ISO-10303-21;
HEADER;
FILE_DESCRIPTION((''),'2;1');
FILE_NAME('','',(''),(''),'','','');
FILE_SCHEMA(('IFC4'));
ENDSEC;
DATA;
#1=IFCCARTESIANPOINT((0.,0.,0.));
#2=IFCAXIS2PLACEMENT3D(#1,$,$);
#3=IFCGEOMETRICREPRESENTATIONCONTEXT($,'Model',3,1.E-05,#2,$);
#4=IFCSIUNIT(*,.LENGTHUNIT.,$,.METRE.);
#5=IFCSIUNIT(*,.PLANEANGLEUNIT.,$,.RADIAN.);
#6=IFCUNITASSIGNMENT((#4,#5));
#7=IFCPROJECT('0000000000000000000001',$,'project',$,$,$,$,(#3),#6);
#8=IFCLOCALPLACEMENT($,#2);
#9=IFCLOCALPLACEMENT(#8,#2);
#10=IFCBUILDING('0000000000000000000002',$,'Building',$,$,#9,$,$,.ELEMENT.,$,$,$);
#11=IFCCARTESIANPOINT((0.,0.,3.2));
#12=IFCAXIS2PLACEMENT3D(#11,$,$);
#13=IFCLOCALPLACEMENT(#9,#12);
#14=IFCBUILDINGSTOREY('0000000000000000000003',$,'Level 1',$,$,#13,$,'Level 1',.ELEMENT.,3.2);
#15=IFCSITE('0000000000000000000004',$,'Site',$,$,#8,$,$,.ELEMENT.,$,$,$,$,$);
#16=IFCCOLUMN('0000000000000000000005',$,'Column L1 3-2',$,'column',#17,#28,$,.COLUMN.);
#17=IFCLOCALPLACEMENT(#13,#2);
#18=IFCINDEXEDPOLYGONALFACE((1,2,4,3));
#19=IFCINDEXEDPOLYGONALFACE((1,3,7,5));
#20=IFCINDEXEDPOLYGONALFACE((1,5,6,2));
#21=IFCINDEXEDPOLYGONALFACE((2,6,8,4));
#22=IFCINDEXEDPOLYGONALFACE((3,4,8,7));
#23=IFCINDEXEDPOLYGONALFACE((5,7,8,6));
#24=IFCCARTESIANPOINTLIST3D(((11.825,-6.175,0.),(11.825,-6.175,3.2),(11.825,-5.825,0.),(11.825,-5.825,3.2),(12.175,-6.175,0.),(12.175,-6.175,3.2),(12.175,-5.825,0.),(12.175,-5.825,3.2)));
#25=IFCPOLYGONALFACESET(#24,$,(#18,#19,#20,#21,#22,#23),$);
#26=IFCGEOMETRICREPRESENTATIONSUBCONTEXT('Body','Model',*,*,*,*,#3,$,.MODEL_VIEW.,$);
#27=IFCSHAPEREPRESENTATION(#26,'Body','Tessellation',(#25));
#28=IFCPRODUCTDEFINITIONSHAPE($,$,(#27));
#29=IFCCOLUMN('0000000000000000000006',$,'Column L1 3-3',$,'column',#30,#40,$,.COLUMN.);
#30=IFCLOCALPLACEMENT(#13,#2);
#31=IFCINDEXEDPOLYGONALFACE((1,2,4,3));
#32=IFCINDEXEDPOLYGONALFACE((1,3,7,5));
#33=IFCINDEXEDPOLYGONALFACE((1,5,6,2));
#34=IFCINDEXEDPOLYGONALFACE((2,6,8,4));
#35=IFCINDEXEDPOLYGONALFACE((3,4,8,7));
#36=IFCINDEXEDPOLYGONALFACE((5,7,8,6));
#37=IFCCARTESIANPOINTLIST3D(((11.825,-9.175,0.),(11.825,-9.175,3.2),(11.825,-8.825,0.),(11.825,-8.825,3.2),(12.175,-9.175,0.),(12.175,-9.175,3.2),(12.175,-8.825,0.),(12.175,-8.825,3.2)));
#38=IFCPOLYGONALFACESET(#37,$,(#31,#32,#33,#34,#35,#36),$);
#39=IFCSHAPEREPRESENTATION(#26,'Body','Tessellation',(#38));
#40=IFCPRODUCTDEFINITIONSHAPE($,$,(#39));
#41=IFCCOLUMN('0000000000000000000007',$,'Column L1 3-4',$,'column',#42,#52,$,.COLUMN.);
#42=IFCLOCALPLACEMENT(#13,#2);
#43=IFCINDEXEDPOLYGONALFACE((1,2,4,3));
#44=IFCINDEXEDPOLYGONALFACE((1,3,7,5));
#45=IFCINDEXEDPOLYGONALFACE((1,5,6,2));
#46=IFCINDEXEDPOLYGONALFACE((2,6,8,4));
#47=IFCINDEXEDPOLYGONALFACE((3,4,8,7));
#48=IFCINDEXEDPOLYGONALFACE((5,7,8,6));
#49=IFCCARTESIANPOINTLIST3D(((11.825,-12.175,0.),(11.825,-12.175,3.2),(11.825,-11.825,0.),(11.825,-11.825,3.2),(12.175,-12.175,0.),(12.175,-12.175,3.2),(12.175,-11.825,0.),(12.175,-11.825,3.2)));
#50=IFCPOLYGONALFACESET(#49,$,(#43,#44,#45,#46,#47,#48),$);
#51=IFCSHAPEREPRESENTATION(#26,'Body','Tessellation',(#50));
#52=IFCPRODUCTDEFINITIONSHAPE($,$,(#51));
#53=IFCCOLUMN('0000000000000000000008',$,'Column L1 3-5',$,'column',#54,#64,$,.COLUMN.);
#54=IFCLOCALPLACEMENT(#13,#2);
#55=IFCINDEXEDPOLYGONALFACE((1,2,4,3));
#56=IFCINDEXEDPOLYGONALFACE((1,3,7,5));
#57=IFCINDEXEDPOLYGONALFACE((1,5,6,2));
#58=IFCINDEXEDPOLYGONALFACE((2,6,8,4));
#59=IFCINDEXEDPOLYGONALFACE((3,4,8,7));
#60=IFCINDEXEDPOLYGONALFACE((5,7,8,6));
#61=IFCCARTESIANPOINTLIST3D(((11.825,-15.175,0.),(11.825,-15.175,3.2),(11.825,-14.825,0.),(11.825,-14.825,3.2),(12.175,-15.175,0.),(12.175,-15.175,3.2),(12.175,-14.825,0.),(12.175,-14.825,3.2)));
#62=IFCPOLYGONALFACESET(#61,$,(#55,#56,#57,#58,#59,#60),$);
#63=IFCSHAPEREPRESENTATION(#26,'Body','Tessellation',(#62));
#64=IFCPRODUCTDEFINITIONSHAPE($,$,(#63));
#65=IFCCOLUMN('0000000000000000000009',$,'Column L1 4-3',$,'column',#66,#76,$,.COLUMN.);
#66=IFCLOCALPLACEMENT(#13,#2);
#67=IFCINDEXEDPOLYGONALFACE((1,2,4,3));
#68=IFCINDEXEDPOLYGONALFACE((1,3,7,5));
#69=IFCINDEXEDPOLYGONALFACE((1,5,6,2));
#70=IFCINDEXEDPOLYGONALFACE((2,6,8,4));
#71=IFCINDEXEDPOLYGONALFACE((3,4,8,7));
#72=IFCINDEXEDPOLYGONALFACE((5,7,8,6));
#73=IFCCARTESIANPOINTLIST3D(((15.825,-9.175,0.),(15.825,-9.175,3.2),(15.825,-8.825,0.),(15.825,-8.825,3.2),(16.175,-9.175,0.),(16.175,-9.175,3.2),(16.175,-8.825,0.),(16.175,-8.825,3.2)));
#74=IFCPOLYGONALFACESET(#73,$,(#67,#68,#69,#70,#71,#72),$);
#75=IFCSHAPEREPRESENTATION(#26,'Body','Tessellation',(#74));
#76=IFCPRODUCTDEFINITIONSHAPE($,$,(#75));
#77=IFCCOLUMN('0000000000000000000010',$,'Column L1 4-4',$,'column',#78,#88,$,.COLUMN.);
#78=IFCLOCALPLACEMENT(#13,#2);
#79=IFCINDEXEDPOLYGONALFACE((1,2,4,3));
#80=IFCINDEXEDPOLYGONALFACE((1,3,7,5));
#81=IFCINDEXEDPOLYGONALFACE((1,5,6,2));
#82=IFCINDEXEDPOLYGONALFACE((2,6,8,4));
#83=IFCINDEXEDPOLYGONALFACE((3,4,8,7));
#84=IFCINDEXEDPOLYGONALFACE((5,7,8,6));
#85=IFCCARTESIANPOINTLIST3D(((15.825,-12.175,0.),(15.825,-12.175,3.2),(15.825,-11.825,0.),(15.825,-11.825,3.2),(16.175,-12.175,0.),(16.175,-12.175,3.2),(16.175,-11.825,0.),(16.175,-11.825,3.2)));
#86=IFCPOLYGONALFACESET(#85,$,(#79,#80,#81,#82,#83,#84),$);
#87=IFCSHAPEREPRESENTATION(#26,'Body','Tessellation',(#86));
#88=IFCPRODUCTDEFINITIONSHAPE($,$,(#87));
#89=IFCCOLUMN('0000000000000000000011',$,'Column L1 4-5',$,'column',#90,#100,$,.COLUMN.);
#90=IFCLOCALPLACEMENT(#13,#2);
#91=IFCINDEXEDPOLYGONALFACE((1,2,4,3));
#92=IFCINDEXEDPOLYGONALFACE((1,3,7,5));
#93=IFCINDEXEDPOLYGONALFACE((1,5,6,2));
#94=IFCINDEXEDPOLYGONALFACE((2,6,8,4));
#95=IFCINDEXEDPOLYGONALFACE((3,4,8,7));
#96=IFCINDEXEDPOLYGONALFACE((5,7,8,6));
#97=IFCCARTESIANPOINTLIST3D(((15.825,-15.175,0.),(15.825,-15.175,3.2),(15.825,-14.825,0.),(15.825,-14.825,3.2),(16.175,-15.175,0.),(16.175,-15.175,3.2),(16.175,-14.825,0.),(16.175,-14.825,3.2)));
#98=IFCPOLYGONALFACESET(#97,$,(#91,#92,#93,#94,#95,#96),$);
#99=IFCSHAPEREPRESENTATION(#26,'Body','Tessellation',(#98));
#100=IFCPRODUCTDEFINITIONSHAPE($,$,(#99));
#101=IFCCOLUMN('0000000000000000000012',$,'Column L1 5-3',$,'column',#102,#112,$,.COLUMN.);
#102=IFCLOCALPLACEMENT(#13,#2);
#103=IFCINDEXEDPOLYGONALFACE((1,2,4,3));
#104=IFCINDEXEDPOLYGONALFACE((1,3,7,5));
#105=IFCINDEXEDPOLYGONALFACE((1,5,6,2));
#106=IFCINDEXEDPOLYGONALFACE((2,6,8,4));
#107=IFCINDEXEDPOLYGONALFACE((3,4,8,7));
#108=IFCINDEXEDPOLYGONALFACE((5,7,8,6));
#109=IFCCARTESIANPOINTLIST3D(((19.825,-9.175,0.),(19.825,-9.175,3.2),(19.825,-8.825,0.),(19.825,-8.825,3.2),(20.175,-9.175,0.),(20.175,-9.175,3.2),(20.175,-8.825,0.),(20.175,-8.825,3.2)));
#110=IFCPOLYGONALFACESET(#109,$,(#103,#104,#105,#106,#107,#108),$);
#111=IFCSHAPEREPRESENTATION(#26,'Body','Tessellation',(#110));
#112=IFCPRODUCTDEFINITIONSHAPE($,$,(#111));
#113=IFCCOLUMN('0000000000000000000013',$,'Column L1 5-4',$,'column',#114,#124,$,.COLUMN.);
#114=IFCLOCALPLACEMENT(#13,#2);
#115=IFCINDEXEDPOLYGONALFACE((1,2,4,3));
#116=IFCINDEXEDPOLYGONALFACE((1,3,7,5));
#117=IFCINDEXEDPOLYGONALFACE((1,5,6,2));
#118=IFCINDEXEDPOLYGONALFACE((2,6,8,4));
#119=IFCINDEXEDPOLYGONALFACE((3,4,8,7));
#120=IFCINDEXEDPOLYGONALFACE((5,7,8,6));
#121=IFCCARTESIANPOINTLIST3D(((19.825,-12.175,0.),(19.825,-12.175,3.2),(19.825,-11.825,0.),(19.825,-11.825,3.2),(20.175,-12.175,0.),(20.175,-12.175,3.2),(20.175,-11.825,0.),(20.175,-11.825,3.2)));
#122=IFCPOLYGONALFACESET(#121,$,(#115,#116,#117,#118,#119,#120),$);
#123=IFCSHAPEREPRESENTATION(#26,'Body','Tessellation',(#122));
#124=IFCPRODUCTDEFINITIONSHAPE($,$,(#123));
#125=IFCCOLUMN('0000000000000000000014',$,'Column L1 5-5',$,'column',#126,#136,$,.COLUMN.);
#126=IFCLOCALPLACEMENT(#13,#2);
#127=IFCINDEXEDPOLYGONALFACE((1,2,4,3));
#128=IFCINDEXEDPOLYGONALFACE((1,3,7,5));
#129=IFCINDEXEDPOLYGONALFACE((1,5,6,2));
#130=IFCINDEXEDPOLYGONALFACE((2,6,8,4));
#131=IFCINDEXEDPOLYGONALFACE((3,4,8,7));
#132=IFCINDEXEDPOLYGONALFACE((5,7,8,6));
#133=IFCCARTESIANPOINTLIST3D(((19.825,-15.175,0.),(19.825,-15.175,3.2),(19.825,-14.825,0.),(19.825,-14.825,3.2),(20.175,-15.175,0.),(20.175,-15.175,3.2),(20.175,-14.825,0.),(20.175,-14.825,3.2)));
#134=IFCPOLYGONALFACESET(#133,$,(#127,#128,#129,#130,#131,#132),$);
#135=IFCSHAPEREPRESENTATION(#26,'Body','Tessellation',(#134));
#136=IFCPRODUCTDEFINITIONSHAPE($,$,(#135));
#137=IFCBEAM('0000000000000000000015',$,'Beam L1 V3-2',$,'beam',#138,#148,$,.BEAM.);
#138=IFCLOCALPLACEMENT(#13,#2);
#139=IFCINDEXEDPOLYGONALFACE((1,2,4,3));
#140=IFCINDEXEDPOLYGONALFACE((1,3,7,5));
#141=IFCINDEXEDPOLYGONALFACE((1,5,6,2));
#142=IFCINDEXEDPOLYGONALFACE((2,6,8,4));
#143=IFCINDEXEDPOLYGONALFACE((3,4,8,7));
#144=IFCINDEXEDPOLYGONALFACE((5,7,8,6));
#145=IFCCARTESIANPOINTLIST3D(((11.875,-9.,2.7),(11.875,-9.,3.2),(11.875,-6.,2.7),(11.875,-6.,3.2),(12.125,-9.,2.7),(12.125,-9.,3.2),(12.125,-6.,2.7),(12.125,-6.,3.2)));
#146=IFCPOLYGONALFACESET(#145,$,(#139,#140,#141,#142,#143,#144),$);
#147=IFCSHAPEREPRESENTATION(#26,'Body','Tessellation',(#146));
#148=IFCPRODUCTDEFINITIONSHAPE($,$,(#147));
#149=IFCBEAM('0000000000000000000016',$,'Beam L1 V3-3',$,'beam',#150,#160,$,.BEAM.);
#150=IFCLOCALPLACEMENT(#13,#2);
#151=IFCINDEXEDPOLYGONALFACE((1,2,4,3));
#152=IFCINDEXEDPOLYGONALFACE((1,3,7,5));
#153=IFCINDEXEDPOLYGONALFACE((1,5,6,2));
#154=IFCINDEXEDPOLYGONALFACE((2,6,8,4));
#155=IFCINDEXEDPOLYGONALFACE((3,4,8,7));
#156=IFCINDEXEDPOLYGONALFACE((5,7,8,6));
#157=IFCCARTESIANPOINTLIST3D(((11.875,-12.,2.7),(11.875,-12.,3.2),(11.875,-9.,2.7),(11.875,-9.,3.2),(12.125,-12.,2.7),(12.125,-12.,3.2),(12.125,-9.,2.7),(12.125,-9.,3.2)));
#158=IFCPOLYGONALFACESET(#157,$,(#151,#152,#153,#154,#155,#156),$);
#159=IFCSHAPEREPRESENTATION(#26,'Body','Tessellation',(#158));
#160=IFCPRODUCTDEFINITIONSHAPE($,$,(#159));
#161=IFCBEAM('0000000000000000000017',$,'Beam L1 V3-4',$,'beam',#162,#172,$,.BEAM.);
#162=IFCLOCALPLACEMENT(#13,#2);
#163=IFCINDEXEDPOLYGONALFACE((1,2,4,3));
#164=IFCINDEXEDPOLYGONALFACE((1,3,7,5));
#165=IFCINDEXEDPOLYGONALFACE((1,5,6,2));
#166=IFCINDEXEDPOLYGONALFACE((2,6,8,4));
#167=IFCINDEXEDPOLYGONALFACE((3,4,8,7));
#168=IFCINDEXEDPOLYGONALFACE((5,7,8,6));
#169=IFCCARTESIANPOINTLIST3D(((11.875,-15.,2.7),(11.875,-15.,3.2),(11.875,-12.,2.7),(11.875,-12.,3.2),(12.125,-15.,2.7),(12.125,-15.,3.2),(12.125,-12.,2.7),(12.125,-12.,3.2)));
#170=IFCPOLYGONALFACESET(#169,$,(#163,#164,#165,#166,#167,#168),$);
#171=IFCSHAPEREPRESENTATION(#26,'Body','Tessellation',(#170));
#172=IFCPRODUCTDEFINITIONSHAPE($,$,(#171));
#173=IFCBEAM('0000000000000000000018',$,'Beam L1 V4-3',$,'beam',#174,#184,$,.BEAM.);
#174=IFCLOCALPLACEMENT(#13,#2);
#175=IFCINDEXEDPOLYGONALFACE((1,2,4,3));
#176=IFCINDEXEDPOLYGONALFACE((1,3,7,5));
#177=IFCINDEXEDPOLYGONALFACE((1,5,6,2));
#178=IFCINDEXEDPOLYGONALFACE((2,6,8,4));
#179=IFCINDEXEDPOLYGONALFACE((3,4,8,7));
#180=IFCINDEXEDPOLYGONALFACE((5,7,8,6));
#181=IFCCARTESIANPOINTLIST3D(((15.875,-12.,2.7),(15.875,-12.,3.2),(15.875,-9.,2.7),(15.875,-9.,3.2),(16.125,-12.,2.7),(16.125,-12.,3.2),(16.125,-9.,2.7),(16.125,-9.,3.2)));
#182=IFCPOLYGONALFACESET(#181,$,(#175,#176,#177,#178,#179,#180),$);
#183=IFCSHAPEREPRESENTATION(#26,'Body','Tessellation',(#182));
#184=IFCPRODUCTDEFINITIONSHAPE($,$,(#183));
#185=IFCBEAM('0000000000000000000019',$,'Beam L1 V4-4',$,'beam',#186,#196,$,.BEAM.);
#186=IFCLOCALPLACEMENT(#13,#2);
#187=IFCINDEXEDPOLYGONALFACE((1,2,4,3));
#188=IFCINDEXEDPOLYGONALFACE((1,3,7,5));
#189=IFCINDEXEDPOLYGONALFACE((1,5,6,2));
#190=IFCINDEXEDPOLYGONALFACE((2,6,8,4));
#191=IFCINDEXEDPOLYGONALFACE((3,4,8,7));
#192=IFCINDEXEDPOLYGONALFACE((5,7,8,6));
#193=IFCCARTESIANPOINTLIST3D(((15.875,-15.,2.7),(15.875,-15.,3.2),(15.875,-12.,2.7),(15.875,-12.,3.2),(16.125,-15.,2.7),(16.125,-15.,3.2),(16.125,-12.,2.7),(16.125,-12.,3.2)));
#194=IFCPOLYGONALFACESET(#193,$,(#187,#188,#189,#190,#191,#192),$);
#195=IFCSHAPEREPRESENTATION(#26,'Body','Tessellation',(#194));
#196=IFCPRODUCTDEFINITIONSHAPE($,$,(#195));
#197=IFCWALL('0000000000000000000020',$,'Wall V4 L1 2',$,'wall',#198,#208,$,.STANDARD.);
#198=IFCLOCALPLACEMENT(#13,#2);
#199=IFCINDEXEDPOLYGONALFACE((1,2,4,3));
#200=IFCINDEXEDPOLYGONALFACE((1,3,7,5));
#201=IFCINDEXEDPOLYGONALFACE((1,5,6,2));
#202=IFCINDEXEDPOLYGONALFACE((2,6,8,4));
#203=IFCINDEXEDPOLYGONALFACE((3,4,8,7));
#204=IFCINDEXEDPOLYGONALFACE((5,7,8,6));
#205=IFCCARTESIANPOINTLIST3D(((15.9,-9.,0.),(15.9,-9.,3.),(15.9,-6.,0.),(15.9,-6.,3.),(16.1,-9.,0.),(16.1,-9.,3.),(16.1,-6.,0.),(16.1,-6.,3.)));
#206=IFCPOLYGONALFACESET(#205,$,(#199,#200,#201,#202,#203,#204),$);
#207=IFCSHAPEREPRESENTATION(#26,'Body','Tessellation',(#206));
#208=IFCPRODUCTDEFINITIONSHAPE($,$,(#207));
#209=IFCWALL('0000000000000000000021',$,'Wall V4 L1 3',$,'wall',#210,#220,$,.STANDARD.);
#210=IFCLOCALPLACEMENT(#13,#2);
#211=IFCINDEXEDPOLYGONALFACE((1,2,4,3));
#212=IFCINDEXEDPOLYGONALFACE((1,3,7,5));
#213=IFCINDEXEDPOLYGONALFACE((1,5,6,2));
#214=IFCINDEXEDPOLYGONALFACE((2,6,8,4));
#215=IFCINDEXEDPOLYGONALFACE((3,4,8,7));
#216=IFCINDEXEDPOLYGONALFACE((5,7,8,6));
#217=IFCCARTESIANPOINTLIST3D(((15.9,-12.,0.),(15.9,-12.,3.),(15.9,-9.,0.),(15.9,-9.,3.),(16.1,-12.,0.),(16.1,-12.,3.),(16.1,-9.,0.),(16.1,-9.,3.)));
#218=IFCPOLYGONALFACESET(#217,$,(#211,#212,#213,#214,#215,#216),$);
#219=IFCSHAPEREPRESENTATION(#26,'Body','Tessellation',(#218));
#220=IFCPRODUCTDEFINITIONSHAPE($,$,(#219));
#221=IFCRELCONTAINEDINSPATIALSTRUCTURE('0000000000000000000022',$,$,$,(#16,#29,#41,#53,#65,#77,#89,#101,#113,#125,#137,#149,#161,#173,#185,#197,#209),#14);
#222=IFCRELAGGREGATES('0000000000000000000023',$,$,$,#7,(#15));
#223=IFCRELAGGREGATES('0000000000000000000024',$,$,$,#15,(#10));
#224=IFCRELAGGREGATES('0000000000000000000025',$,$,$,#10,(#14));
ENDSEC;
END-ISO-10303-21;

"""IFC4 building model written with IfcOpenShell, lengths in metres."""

from ifc_helpers import new_model, si_unit, frame, frame_2d, origin, origin_2d, place, context, subcontext, project, spatial, rectangle, extrude, element, save


model = new_model("IFC4")

# Units and contexts
model_context = context("Model", 3, precision=1e-05, world=origin())
body_context = subcontext(model_context, "Body", "Model", "MODEL_VIEW")
ifc_project = project(units=[si_unit("LENGTHUNIT", "METRE"), si_unit("PLANEANGLEUNIT", "RADIAN")], contexts=[model_context])

# Site, building, storey
site_placement = place(None, origin())
site = spatial("IfcSite", under=ifc_project, at=site_placement, Name="Site", CompositionType="ELEMENT")
building_placement = place(site_placement, origin())
building = spatial("IfcBuilding", under=site, at=building_placement, Name="Building", CompositionType="ELEMENT")
storey_placement = place(building_placement, frame((0.0, 0.0, 3.2)))
storey = spatial("IfcBuildingStorey", under=building, at=storey_placement, Name="Level 1", LongName="Level 1", CompositionType="ELEMENT", Elevation=3.2)

# Columns
for number, where, name in (
    (1, (12.0, -6.0, 0.0), "Column L1 3-2"),
    (2, (12.0, -9.0, 0.0), "Column L1 3-3"),
    (3, (12.0, -12.0, 0.0), "Column L1 3-4"),
    (4, (12.0, -15.0, 0.0), "Column L1 3-5"),
    (5, (16.0, -9.0, 0.0), "Column L1 4-3"),
    (6, (16.0, -12.0, 0.0), "Column L1 4-4"),
    (7, (16.0, -15.0, 0.0), "Column L1 4-5"),
    (8, (20.0, -9.0, 0.0), "Column L1 5-3"),
    (9, (20.0, -12.0, 0.0), "Column L1 5-4"),
    (10, (20.0, -15.0, 0.0), "Column L1 5-5"),
):
    element("IfcColumn", number, at=place(storey_placement, frame(where)), inside=storey, Name=name, ObjectType="column", PredefinedType="COLUMN", context=body_context, shape_type="SweptSolid", body=[
        extrude(rectangle(XDim=0.35, YDim=0.35, at=origin_2d()), origin(), (0.0, 0.0, 1.0), 3.2),
    ])

# Beams
for number, where, z_axis, x_axis, name in (
    (11, (12.0, -6.0, 2.95), (0.0, -1.0, 0.0), (0.0, 0.0, 1.0), "Beam L1 V3-2"),
    (12, (12.0, -9.0, 2.95), (0.0, -1.0, 0.0), (0.0, 0.0, 1.0), "Beam L1 V3-3"),
    (13, (12.0, -12.0, 2.95), (0.0, -1.0, 0.0), (0.0, 0.0, 1.0), "Beam L1 V3-4"),
    (14, (16.0, -9.0, 2.95), (0.0, -1.0, 0.0), (0.0, 0.0, 1.0), "Beam L1 V4-3"),
    (15, (16.0, -12.0, 2.95), (0.0, -1.0, 0.0), (0.0, 0.0, 1.0), "Beam L1 V4-4"),
):
    element("IfcBeam", number, at=place(storey_placement, frame(where, z_axis=z_axis, x_axis=x_axis)), inside=storey, Name=name, ObjectType="beam", PredefinedType="BEAM", context=body_context, shape_type="SweptSolid", body=[
        extrude(rectangle(XDim=0.5, YDim=0.25, at=origin_2d()), origin(), (0.0, 0.0, 1.0), 3.0),
    ])

# Walls
for number, where, z_axis, x_axis, name in (
    (16, (16.0, -6.0, 0.0), (0.0, 0.0, 1.0), (0.0, -1.0, 0.0), "Wall V4 L1 2"),
    (17, (16.0, -9.0, 0.0), (0.0, 0.0, 1.0), (0.0, -1.0, 0.0), "Wall V4 L1 3"),
):
    element("IfcWall", number, at=place(storey_placement, frame(where, z_axis=z_axis, x_axis=x_axis)), inside=storey, Name=name, ObjectType="wall", PredefinedType="STANDARD", context=body_context, shape_type="SweptSolid", body=[
        extrude(rectangle(XDim=3.0, YDim=0.2, at=frame_2d((1.5, 0.0))), origin(), (0.0, 0.0, 1.0), 3.0),
    ])

save(model, "model.ifc")
